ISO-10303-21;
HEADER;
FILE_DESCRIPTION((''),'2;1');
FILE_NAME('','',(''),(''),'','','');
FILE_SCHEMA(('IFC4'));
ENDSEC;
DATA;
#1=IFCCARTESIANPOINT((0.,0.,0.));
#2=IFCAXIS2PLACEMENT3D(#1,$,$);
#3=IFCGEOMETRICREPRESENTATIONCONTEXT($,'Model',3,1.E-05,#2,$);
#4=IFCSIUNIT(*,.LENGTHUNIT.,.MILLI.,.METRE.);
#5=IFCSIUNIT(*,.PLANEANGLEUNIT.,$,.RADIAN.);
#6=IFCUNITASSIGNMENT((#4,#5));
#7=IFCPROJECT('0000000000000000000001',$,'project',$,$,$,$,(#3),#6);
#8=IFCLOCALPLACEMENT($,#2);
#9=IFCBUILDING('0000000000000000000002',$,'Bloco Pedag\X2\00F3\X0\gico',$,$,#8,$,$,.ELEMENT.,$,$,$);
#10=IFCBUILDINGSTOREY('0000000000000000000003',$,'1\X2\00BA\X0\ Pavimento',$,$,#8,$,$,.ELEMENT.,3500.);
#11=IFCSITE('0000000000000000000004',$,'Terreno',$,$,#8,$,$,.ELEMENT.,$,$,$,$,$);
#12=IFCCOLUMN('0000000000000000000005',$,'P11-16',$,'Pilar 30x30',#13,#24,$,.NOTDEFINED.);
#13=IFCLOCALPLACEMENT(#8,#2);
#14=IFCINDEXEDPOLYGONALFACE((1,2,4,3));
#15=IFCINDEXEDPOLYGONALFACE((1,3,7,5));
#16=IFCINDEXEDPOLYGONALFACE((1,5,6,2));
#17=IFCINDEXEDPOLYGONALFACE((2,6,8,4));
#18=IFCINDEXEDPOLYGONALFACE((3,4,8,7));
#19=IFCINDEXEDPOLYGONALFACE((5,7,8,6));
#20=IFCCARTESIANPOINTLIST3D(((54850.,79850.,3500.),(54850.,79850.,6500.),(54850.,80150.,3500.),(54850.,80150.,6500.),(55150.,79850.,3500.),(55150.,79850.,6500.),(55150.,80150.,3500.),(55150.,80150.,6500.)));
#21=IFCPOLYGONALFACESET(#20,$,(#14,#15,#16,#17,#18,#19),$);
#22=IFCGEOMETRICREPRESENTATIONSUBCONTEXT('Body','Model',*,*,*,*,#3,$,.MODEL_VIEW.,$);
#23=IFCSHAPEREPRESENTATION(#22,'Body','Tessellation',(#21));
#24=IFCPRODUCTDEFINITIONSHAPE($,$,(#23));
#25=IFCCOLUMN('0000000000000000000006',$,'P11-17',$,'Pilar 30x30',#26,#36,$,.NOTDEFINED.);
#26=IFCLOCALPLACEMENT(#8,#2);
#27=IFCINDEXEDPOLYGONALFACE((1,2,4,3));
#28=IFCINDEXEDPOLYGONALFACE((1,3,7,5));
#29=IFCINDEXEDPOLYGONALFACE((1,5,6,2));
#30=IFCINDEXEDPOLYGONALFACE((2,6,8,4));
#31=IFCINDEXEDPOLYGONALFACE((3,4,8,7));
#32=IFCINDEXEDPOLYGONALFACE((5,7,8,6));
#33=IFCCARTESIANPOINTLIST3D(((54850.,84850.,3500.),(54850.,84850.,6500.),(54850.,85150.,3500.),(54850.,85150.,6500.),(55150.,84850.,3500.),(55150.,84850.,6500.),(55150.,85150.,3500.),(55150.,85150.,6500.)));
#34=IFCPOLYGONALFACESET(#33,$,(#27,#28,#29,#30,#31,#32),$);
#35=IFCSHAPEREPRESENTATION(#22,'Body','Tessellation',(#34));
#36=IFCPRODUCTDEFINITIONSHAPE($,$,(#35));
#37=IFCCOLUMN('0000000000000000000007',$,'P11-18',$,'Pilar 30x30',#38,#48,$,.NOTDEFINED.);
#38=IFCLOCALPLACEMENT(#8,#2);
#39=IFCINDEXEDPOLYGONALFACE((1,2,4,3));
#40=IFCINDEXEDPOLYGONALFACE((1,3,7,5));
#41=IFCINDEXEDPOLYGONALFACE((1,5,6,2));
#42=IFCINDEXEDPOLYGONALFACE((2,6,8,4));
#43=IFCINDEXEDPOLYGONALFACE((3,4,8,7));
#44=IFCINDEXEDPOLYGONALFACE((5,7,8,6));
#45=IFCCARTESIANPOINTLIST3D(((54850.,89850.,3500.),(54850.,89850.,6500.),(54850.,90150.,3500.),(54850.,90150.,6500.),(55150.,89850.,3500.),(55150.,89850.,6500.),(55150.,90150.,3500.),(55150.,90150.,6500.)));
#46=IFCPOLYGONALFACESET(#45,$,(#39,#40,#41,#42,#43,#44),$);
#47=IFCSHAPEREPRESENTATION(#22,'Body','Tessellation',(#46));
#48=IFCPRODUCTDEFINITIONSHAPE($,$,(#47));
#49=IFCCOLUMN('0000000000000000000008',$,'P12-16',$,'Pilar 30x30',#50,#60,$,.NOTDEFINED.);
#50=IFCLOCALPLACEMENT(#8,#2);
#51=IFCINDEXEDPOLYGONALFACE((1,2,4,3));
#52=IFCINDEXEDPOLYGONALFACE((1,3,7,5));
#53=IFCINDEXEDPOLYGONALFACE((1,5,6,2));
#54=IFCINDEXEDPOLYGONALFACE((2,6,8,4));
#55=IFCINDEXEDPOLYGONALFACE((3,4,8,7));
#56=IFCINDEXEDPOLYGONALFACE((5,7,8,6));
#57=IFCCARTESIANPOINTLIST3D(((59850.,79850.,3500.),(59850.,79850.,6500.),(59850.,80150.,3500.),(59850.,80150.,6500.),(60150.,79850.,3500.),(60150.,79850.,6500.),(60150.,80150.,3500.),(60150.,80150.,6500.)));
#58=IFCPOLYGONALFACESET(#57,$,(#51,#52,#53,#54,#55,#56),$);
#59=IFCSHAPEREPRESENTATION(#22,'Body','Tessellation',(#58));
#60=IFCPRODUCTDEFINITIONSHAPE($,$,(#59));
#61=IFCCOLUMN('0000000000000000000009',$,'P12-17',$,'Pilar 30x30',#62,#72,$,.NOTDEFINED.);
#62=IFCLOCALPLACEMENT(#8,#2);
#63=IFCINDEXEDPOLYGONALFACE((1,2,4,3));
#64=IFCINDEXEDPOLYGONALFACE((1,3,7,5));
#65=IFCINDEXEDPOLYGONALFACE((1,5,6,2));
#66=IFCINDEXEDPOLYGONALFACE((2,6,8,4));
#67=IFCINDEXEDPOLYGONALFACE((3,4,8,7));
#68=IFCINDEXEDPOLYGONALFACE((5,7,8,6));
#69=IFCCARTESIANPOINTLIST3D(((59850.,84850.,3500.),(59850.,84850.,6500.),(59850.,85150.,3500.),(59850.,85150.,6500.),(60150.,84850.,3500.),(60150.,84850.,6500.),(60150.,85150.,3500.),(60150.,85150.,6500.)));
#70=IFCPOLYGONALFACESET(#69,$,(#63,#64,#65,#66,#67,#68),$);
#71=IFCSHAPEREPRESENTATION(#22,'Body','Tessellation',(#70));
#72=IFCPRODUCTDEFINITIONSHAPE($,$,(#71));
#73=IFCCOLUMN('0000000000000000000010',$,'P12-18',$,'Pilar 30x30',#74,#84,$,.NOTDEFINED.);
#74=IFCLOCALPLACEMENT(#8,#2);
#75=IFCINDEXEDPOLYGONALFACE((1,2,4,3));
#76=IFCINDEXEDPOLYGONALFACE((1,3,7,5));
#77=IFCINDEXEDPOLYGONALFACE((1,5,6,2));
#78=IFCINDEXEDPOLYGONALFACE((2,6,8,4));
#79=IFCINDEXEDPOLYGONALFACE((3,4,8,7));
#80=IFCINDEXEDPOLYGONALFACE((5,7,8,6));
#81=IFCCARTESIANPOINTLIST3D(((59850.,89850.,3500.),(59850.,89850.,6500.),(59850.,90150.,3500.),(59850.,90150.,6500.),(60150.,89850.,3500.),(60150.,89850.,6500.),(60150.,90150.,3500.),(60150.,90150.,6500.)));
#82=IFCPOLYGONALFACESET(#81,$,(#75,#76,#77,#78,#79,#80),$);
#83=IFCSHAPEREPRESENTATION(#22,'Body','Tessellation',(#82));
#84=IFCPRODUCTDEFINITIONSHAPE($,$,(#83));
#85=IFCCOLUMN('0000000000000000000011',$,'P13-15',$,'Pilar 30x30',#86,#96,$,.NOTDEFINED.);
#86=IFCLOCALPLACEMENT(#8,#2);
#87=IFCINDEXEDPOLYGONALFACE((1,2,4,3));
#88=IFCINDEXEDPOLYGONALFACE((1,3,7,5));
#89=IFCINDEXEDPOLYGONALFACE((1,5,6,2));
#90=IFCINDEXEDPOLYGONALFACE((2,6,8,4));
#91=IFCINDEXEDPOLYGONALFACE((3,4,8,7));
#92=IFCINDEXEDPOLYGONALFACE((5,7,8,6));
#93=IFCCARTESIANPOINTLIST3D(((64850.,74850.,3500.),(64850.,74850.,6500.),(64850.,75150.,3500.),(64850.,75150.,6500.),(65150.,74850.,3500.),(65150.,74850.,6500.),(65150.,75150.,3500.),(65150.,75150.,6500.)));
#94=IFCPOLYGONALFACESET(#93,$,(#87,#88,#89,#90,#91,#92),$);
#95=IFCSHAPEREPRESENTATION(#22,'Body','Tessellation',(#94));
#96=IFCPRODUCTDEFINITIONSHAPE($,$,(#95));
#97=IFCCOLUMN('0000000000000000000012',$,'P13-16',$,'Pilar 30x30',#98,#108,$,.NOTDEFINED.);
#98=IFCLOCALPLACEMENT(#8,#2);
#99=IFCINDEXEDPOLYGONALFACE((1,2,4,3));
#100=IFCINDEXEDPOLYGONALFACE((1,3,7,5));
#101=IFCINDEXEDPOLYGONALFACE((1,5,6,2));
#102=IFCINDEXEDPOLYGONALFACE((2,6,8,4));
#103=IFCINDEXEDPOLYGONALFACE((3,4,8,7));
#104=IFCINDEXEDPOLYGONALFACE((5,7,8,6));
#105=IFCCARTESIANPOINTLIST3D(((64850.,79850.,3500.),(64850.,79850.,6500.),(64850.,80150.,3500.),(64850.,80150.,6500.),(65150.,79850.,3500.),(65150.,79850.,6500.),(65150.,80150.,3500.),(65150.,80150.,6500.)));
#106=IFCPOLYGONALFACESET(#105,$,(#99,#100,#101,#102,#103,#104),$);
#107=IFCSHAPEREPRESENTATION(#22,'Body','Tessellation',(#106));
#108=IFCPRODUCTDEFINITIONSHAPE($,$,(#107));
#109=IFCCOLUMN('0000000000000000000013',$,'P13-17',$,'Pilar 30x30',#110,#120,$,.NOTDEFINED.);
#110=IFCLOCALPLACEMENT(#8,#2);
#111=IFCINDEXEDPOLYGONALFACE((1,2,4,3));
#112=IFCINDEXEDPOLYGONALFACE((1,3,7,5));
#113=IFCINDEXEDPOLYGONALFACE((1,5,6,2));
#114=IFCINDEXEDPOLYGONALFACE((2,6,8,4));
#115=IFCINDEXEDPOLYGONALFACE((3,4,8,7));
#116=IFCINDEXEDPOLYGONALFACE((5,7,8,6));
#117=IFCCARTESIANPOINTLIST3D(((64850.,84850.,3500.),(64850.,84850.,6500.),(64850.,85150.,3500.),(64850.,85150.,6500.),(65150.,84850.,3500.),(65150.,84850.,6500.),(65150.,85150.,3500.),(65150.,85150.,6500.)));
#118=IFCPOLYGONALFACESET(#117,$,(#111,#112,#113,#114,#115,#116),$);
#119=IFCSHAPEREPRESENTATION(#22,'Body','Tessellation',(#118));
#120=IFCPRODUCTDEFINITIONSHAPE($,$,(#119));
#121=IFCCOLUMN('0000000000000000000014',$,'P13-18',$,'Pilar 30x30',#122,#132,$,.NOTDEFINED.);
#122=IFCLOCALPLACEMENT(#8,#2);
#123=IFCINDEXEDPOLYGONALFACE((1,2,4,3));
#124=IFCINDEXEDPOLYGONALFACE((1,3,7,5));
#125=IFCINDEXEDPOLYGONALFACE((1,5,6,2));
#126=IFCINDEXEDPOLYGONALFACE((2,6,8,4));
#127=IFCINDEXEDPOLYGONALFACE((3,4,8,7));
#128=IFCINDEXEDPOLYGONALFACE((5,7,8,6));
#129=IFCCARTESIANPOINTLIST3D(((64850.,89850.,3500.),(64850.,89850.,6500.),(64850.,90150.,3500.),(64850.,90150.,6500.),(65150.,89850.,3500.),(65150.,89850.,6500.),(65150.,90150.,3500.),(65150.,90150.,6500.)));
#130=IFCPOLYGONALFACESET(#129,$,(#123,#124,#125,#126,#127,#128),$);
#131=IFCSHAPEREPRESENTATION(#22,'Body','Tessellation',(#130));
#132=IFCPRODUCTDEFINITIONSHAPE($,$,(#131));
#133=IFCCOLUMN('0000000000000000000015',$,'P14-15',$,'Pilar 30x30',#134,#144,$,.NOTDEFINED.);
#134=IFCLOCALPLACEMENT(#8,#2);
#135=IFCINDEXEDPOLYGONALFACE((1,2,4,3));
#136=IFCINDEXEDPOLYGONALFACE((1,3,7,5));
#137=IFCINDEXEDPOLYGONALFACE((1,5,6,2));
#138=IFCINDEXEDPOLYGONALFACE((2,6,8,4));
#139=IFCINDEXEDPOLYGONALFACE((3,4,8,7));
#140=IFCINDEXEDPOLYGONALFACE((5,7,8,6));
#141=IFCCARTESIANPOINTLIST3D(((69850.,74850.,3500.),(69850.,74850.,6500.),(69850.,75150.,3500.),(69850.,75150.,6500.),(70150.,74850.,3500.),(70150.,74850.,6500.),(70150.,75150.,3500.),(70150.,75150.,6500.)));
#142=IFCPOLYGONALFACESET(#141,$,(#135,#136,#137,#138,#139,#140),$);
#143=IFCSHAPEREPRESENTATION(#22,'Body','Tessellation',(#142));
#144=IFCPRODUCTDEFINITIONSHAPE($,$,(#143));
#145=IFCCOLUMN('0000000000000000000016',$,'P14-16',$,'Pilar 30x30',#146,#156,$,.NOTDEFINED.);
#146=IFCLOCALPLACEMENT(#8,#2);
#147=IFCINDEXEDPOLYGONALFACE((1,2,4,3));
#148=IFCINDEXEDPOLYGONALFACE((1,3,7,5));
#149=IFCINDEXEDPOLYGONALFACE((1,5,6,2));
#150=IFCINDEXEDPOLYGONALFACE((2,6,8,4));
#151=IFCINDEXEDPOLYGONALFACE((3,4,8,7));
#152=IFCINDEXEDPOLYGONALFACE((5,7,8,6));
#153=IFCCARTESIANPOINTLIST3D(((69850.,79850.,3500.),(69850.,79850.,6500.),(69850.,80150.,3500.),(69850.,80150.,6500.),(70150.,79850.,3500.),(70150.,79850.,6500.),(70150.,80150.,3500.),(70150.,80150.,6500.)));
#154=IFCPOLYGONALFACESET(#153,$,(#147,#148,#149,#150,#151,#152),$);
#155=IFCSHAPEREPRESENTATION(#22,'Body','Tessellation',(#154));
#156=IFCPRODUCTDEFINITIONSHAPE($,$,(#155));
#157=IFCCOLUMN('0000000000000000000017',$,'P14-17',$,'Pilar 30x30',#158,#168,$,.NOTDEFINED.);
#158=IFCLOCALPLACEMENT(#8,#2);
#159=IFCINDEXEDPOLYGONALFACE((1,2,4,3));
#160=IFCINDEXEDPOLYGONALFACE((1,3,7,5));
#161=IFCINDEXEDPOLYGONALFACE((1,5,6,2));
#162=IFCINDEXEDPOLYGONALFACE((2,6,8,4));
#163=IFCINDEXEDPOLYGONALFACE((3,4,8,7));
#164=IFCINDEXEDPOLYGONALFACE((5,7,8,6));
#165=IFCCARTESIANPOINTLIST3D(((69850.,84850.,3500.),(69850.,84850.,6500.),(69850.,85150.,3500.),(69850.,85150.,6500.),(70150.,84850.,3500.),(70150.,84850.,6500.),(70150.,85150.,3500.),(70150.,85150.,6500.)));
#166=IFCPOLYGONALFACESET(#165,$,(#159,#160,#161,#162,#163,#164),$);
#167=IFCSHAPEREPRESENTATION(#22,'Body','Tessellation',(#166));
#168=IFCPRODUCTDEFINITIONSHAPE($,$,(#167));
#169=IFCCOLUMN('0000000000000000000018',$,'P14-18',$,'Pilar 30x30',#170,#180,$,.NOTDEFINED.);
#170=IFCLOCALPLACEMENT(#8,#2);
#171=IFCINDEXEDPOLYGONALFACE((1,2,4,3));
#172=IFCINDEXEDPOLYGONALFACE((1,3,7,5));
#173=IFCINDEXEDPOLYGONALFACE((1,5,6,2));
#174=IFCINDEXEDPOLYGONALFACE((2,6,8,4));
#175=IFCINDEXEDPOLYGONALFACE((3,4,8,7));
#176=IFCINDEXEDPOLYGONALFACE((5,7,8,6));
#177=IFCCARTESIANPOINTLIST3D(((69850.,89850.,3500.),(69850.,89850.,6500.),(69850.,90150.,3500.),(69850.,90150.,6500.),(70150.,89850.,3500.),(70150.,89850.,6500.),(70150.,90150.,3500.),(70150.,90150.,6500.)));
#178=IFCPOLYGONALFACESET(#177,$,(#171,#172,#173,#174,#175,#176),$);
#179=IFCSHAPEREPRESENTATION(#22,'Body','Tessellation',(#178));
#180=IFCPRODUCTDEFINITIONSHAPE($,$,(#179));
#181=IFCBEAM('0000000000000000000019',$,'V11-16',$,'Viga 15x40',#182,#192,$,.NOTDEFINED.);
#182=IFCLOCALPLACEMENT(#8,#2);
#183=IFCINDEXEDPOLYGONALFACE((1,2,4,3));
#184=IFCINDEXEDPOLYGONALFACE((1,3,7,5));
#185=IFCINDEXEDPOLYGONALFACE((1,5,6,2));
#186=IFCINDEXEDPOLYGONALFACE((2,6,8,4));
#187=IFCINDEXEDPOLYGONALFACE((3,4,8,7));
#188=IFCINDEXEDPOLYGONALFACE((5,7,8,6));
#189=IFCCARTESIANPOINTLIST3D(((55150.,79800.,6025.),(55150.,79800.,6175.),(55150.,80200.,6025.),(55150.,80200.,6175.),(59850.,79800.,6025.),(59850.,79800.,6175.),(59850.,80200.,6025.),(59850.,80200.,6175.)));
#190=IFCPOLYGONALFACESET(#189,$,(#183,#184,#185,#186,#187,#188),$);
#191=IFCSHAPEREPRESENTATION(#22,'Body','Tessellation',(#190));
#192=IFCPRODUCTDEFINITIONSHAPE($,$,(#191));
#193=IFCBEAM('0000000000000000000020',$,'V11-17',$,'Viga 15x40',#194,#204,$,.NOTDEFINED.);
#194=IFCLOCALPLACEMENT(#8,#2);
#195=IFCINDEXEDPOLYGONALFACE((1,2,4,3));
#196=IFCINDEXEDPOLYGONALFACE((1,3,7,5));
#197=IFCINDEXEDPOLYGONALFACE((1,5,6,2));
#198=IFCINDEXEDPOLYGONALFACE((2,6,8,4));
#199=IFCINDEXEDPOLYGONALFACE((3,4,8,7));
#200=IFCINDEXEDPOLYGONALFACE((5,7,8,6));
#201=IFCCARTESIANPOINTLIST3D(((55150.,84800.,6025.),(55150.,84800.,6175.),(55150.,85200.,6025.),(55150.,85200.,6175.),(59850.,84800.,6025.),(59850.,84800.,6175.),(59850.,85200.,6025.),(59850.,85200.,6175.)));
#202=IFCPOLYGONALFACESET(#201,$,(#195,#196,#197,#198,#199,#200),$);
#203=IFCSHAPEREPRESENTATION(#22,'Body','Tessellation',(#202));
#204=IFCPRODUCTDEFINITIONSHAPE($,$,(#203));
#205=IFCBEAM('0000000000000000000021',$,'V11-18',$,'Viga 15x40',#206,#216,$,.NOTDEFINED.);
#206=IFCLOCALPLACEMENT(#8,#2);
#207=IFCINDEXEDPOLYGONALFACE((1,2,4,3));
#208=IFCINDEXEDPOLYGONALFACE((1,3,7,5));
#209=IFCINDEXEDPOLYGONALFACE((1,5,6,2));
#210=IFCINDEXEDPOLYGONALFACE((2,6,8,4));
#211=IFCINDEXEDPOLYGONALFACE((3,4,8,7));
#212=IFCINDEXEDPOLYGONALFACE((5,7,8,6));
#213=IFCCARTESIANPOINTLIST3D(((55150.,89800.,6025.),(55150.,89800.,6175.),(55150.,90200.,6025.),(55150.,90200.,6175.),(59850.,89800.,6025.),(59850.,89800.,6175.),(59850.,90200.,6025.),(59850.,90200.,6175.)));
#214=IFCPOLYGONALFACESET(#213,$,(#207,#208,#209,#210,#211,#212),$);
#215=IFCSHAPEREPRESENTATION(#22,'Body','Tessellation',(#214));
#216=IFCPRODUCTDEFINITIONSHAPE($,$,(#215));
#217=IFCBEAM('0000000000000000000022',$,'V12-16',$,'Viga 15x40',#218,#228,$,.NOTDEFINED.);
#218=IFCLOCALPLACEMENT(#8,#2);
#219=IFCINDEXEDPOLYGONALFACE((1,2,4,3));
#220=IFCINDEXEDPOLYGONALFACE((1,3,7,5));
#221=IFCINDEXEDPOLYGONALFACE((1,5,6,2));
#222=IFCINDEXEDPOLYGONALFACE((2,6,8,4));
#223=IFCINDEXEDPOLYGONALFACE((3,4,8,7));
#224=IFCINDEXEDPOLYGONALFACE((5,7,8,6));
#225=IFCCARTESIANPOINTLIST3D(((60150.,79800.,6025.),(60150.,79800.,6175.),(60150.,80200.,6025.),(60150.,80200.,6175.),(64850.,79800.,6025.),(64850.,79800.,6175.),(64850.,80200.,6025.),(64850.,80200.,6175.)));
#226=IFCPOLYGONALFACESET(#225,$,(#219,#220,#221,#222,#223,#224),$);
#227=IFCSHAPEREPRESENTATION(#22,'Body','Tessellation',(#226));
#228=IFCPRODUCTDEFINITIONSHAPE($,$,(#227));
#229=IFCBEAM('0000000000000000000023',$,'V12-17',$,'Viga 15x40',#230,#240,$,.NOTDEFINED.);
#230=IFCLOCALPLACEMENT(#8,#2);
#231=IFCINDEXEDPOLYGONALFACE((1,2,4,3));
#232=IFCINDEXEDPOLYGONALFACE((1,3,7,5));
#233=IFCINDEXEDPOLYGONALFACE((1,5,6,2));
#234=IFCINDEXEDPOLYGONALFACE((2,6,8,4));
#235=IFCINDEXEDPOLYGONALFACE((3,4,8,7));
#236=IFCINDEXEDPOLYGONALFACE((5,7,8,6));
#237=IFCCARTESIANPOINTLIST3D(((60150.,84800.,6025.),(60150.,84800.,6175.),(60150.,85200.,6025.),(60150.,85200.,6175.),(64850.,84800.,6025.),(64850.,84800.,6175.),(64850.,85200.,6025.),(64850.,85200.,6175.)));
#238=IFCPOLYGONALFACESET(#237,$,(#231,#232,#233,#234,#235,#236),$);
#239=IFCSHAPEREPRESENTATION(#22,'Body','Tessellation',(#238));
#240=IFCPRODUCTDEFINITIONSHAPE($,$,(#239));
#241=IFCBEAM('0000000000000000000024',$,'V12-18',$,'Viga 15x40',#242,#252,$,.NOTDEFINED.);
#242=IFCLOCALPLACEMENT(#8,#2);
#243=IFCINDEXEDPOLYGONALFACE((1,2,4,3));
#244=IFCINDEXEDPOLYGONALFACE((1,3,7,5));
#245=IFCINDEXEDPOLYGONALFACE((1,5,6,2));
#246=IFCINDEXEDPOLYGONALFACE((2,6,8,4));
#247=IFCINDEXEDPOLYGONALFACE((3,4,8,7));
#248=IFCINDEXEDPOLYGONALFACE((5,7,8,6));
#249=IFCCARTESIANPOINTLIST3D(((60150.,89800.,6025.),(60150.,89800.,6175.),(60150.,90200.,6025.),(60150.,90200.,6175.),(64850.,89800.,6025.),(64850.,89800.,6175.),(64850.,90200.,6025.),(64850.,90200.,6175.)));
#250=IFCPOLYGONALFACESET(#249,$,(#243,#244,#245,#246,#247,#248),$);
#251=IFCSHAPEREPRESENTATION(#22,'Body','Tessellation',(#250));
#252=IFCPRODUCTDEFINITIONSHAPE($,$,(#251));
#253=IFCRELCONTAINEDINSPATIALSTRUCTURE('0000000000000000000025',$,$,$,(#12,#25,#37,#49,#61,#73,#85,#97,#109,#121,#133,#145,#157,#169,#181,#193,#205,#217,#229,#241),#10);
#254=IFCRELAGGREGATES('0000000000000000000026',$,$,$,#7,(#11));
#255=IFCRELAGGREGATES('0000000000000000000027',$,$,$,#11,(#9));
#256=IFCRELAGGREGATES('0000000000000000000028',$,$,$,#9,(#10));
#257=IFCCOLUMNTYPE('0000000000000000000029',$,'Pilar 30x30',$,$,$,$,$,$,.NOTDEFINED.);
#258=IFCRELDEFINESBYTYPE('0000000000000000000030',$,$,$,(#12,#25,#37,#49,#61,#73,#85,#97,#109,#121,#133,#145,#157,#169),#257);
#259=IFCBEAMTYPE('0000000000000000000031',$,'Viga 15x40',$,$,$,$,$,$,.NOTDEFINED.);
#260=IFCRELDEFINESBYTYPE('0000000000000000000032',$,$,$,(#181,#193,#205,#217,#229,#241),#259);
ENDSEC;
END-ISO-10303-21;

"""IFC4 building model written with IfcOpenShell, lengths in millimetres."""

from ifc_helpers import new_model, si_unit, frame, origin, origin_2d, place, context, subcontext, project, spatial, rectangle, extrude, type_object, element, save


model = new_model("IFC4")

# Units and contexts
model_context = context("Model", 3, precision=1e-05, world=origin())
body_context = subcontext(model_context, "Body", "Model", "MODEL_VIEW")
ifc_project = project(units=[si_unit("LENGTHUNIT", "METRE", prefix="MILLI"), si_unit("PLANEANGLEUNIT", "RADIAN")], contexts=[model_context])

# Site, building, storey
placement = place(None, origin())
site = spatial("IfcSite", under=ifc_project, at=placement, Name="Terreno", CompositionType="ELEMENT")
building = spatial("IfcBuilding", under=site, at=placement, Name="Bloco Pedagógico", CompositionType="ELEMENT")
storey = spatial("IfcBuildingStorey", under=building, at=placement, Name="1º Pavimento", CompositionType="ELEMENT", Elevation=3500.0)

# Columns
column_type = type_object("IfcColumnType", Name="Pilar 30x30", PredefinedType="NOTDEFINED")
for number, where, z_axis, x_axis, name in (
    (1, (55000.0, 80000.0, 3500.0), (0.0, 0.0, 1.0), (1.0, 0.0, 0.0), "P11-16"),
    (2, (55000.0, 85000.0, 3500.0), (0.0, 0.0, 1.0), (1.0, 0.0, 0.0), "P11-17"),
    (3, (55000.0, 90000.0, 3500.0), (0.0, 0.0, 1.0), (1.0, 0.0, 0.0), "P11-18"),
    (4, (60000.0, 80000.0, 3500.0), (0.0, 0.0, 1.0), (1.0, 0.0, 0.0), "P12-16"),
    (5, (60000.0, 85000.0, 3500.0), (0.0, 0.0, 1.0), (1.0, 0.0, 0.0), "P12-17"),
    (6, (60000.0, 90000.0, 3500.0), (0.0, 0.0, 1.0), (1.0, 0.0, 0.0), "P12-18"),
    (7, (65000.0, 75000.0, 3500.0), (0.0, 0.0, 1.0), (1.0, 0.0, 0.0), "P13-15"),
    (8, (65000.0, 80000.0, 3500.0), (0.0, 0.0, 1.0), (1.0, 0.0, 0.0), "P13-16"),
    (9, (65000.0, 85000.0, 3500.0), (0.0, 0.0, 1.0), (1.0, 0.0, 0.0), "P13-17"),
    (10, (65000.0, 90000.0, 3500.0), (0.0, 0.0, 1.0), (1.0, 0.0, 0.0), "P13-18"),
    (11, (70000.0, 75000.0, 3500.0), (0.0, 0.0, 1.0), (1.0, 0.0, 0.0), "P14-15"),
    (12, (70000.0, 80000.0, 3500.0), (0.0, 0.0, 1.0), (1.0, 0.0, 0.0), "P14-16"),
    (13, (70000.0, 85000.0, 3500.0), (0.0, 0.0, 1.0), (1.0, 0.0, 0.0), "P14-17"),
    (14, (70000.0, 90000.0, 3500.0), (0.0, 0.0, 1.0), (1.0, 0.0, 0.0), "P14-18"),
):
    element("IfcColumn", number, at=place(None, frame(where, z_axis=z_axis, x_axis=x_axis)), inside=storey, type_object=column_type, Name=name, ObjectType="Pilar 30x30", PredefinedType="NOTDEFINED", context=body_context, shape_type="SweptSolid", body=[
        extrude(rectangle(XDim=300.0, YDim=300.0, at=origin_2d()), None, (0.0, 0.0, 1.0), 3000.0),
    ])

# Beams
beam_type = type_object("IfcBeamType", Name="Viga 15x40", PredefinedType="NOTDEFINED")
for number, where, z_axis, x_axis, name in (
    (15, (55150.0, 80000.0, 6100.0), (1.0, 0.0, 0.0), (0.0, 1.0, 0.0), "V11-16"),
    (16, (55150.0, 85000.0, 6100.0), (1.0, 0.0, 0.0), (0.0, 1.0, 0.0), "V11-17"),
    (17, (55150.0, 90000.0, 6100.0), (1.0, 0.0, 0.0), (0.0, 1.0, 0.0), "V11-18"),
    (18, (60150.0, 80000.0, 6100.0), (1.0, 0.0, 0.0), (0.0, 1.0, 0.0), "V12-16"),
    (19, (60150.0, 85000.0, 6100.0), (1.0, 0.0, 0.0), (0.0, 1.0, 0.0), "V12-17"),
    (20, (60150.0, 90000.0, 6100.0), (1.0, 0.0, 0.0), (0.0, 1.0, 0.0), "V12-18"),
):
    element("IfcBeam", number, at=place(None, frame(where, z_axis=z_axis, x_axis=x_axis)), inside=storey, type_object=beam_type, Name=name, ObjectType="Viga 15x40", PredefinedType="NOTDEFINED", context=body_context, shape_type="SweptSolid", body=[
        extrude(rectangle(XDim=400.0, YDim=150.0, at=origin_2d()), None, (0.0, 0.0, 1.0), 4700.0),
    ])

save(model, "model.ifc")
